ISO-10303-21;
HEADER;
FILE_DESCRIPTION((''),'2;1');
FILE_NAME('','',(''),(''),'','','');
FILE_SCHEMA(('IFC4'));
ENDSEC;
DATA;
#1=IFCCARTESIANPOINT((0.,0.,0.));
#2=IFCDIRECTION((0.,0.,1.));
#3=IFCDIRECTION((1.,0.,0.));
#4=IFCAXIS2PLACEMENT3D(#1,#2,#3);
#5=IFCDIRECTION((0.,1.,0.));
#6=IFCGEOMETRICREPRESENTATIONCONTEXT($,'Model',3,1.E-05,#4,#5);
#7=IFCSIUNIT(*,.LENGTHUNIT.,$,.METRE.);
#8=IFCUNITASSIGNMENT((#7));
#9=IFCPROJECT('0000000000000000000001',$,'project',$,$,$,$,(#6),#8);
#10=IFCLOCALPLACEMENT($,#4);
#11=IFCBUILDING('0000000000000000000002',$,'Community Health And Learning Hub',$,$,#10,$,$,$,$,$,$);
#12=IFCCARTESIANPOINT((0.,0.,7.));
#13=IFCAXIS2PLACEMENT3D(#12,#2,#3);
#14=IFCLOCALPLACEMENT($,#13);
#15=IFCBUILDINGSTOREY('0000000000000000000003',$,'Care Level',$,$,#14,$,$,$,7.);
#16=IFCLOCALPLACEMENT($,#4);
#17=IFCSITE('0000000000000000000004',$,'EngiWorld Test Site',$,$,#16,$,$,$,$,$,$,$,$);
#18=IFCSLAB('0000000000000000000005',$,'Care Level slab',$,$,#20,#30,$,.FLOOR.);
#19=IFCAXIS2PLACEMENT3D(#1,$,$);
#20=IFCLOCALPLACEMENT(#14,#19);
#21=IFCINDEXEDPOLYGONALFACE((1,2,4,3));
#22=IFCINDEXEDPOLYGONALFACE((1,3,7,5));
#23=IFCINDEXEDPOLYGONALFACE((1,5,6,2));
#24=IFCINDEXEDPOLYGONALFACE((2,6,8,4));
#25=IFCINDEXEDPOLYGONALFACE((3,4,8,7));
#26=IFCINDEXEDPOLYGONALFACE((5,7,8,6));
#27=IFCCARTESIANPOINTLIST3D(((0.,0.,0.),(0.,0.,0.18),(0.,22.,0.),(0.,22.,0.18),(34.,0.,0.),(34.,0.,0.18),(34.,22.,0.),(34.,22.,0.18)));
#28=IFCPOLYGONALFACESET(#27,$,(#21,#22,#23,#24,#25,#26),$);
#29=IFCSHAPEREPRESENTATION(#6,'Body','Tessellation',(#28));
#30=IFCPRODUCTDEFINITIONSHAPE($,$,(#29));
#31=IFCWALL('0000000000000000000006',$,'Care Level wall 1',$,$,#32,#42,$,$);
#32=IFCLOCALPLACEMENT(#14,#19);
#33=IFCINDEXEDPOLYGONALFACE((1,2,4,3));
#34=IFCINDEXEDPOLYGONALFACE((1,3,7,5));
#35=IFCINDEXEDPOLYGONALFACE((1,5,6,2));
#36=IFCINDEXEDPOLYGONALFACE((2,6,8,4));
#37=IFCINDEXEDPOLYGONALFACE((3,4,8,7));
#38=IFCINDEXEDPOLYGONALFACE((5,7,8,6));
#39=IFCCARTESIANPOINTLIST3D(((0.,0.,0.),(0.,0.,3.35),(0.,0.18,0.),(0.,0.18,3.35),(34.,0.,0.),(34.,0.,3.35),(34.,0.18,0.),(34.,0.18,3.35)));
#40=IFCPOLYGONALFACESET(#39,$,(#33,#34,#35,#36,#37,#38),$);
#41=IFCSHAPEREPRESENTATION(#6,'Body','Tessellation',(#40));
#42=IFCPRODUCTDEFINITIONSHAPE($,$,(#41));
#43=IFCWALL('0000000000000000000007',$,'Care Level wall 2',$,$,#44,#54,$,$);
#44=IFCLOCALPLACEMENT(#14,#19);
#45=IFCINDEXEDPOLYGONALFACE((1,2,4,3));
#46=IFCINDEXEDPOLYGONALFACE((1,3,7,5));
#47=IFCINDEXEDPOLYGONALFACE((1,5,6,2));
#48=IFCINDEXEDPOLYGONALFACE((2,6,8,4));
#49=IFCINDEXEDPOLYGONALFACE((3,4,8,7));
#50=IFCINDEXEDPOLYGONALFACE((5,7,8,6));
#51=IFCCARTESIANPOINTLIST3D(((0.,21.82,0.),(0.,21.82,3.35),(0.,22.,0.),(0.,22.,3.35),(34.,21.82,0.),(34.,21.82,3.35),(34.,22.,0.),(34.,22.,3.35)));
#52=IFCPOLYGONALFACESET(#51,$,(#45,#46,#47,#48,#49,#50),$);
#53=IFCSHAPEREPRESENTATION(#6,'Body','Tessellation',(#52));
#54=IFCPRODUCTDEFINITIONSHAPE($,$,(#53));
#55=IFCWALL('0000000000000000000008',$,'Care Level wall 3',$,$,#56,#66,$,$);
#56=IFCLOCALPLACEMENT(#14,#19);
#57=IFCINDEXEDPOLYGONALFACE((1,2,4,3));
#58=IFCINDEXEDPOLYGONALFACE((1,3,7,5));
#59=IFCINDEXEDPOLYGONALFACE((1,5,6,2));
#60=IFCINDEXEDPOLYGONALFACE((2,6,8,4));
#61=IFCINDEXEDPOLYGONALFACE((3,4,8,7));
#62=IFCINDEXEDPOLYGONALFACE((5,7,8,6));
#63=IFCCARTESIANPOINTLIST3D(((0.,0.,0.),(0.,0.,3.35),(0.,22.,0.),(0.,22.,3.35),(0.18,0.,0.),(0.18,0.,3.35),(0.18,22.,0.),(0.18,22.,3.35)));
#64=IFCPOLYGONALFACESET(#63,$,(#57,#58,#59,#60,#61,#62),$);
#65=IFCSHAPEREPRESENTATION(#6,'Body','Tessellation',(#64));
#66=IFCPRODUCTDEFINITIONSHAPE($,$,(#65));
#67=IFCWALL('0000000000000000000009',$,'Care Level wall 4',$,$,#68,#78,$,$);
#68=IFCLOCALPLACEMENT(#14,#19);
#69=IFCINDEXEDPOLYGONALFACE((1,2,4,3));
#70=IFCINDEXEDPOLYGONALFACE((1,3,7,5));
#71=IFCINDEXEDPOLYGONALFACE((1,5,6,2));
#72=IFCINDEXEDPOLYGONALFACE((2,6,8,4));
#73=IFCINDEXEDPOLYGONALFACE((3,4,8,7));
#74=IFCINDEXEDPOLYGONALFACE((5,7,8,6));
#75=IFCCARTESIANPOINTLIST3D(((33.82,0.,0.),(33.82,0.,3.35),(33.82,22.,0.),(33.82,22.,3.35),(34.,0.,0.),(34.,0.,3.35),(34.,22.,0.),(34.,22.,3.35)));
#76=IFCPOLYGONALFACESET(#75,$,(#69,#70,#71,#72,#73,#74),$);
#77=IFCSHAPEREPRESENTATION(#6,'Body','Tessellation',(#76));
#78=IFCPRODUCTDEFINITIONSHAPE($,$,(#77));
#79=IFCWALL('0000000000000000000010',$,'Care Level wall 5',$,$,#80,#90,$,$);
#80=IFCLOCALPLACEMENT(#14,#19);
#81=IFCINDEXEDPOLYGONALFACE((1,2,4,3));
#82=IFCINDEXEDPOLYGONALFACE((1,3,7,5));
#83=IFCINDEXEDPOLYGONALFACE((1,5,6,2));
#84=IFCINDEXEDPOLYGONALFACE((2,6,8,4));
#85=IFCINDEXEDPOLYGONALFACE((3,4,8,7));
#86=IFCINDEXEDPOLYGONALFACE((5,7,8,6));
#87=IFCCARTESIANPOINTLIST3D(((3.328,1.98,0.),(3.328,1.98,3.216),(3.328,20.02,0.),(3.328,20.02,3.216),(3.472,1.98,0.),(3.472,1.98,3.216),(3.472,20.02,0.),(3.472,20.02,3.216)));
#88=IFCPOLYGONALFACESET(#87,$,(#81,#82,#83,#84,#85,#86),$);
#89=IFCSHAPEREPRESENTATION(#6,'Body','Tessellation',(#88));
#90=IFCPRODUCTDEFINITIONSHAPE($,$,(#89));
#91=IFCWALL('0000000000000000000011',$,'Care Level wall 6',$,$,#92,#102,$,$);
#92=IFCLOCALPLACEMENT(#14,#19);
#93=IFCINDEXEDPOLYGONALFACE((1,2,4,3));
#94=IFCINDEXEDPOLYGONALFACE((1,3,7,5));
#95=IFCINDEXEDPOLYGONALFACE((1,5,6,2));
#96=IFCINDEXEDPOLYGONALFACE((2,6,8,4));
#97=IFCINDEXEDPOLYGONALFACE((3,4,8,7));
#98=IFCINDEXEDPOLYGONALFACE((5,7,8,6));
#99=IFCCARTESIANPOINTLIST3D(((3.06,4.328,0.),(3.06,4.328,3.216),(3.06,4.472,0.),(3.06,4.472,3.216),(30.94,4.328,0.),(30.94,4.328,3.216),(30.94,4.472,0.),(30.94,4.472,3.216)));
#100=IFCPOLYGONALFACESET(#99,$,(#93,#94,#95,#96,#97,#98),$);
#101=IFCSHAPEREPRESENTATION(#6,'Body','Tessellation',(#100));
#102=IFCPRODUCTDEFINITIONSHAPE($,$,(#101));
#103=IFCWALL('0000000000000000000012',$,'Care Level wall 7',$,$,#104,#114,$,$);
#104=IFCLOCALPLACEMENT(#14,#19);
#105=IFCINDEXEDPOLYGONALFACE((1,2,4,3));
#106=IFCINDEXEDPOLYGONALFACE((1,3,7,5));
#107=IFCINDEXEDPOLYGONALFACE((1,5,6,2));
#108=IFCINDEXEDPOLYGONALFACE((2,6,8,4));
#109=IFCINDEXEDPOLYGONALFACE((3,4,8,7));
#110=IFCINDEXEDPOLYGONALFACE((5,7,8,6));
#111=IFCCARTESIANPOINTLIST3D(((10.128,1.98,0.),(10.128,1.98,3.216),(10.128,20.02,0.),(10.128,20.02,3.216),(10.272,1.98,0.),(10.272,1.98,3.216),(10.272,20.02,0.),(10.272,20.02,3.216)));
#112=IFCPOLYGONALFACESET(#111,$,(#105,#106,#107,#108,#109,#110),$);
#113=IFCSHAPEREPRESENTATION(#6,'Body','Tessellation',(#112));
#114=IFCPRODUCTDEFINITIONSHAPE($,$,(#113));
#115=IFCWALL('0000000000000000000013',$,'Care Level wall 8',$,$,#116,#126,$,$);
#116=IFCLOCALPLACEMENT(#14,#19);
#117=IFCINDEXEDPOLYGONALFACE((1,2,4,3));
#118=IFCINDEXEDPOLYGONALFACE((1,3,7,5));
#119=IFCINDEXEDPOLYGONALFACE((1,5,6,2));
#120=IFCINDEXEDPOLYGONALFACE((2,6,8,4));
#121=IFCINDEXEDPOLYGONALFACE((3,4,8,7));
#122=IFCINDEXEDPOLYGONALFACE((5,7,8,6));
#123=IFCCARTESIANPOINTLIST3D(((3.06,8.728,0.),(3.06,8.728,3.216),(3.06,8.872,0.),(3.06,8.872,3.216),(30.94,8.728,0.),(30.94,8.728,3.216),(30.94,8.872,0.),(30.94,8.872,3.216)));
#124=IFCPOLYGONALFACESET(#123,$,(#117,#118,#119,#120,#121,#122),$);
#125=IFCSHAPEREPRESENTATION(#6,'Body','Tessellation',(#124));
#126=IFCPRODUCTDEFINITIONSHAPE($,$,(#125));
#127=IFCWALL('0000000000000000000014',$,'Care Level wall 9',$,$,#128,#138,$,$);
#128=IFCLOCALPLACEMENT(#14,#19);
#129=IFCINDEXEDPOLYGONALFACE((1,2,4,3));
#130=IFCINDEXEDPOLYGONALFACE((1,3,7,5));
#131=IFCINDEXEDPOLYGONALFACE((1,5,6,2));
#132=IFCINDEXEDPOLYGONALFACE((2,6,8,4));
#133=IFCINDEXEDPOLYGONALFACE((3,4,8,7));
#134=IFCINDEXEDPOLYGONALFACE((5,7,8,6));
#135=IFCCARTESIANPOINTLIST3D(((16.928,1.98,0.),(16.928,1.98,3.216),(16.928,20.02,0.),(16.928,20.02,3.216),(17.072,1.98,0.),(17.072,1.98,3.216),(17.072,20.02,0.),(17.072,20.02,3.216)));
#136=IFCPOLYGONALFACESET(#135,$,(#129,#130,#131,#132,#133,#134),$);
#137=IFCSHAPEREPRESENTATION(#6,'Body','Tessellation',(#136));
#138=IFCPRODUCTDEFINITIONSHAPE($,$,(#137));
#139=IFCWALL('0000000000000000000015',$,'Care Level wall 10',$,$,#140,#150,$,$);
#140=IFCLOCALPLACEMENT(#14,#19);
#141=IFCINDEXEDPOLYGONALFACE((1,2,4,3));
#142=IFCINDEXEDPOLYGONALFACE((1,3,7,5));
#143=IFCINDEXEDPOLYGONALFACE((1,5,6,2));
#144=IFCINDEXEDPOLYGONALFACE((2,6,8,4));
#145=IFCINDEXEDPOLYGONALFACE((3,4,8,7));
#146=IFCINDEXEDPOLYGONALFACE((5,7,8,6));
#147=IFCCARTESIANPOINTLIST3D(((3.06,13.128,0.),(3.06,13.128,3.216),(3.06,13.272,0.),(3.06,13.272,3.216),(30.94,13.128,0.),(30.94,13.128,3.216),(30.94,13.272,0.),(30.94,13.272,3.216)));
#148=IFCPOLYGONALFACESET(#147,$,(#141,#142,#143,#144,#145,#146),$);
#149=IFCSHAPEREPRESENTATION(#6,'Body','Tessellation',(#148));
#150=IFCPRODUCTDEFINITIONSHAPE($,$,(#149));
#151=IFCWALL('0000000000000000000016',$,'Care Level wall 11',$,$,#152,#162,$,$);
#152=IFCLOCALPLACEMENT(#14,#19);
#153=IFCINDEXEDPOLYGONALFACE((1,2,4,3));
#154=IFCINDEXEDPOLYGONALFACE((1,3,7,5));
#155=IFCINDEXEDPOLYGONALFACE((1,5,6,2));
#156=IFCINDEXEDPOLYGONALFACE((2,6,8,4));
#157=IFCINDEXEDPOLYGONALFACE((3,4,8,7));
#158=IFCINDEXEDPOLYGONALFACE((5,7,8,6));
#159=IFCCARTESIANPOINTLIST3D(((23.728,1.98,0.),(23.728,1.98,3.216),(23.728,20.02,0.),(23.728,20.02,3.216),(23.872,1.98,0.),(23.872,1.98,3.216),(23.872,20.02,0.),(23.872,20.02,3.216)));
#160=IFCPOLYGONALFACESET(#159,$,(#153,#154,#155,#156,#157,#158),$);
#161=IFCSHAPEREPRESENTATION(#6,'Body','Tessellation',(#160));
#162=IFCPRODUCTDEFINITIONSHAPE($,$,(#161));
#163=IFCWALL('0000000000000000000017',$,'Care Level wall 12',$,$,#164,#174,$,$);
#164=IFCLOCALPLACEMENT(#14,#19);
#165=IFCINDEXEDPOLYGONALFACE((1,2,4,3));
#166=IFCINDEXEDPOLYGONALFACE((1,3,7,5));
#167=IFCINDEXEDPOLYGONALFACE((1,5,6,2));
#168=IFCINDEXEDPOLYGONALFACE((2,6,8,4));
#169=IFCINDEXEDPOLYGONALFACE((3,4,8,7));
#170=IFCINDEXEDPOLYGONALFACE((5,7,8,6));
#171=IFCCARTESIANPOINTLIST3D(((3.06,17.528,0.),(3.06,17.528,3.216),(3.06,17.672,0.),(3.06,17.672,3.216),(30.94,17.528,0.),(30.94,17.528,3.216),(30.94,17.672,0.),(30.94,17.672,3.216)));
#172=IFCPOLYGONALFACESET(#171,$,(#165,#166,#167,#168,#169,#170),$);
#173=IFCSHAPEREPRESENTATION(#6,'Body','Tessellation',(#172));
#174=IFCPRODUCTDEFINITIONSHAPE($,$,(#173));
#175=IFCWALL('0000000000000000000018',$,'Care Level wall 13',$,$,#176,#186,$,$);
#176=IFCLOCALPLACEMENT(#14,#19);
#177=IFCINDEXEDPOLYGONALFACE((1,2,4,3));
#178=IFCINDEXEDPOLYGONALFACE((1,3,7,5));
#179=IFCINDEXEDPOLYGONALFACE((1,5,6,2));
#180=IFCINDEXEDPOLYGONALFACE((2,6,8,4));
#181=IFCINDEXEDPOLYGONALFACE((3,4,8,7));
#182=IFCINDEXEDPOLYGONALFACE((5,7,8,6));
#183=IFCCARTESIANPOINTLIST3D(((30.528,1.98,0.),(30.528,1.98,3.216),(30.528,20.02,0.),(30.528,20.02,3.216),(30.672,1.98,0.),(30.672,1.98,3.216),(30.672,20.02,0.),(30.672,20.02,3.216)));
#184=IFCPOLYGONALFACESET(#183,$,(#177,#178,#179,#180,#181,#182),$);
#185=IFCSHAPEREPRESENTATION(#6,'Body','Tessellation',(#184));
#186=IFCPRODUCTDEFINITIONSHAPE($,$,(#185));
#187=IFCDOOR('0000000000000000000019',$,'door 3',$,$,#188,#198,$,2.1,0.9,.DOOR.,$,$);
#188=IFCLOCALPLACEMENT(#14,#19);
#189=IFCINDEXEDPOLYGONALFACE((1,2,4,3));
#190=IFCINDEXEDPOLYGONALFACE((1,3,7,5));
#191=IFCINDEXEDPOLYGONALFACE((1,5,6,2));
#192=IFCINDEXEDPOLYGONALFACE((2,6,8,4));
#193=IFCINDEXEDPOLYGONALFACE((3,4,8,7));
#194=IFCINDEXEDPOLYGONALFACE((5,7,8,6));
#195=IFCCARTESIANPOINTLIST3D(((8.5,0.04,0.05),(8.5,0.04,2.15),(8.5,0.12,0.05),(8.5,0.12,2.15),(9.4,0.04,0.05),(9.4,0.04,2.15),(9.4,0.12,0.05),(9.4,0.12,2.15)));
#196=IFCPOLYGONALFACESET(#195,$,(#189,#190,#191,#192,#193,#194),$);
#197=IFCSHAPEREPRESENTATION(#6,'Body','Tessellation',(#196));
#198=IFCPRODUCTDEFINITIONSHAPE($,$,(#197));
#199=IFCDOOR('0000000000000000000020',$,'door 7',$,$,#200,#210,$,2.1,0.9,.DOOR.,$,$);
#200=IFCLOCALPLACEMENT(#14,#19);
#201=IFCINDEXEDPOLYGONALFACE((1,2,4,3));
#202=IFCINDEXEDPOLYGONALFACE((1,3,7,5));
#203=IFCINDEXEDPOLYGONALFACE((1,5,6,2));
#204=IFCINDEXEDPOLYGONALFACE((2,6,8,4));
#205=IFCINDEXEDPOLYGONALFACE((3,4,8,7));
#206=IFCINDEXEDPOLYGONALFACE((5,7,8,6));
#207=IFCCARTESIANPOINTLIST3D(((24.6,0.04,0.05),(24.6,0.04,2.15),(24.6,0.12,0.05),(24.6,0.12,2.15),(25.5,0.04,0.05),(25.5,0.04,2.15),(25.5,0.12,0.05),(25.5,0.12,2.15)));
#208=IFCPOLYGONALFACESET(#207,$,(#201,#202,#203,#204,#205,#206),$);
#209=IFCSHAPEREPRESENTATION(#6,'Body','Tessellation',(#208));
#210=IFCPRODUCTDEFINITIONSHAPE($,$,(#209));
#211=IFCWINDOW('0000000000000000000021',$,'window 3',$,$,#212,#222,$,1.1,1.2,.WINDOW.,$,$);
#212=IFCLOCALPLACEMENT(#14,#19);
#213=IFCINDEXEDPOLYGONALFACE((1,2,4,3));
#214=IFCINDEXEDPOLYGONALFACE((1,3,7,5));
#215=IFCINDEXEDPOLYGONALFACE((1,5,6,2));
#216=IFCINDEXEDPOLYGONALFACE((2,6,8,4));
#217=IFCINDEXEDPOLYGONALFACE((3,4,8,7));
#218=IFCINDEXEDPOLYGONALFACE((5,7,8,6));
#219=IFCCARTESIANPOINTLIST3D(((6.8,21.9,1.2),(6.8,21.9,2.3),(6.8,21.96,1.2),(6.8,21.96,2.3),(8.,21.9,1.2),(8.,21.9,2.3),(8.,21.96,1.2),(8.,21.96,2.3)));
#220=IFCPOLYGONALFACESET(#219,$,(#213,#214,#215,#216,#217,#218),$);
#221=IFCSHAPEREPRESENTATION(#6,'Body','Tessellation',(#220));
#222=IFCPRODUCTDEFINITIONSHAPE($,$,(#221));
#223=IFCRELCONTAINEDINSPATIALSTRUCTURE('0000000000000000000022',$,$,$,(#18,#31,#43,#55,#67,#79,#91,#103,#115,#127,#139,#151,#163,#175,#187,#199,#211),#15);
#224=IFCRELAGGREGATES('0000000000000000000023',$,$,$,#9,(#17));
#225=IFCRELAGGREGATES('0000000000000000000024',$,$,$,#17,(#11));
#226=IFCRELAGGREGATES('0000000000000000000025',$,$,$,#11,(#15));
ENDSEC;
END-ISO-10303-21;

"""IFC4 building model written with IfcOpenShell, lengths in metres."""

from ifc_helpers import new_model, si_unit, direction, frame, origin_with_axes, origin_2d_with_axis, place, context, project, spatial, rectangle, extrude, element, save


model = new_model("IFC4")

# Units and contexts
model_context = context("Model", 3, precision=1e-05, world=origin_with_axes(), true_north=direction((0.0, 1.0, 0.0)))
ifc_project = project(units=[si_unit("LENGTHUNIT", "METRE")], contexts=[model_context])

# Site, building, storey
site_placement = place(None, origin_with_axes())
site = spatial("IfcSite", under=ifc_project, at=site_placement, Name="EngiWorld Test Site")
building_placement = place(None, origin_with_axes())
building = spatial("IfcBuilding", under=site, at=building_placement, Name="Community Health And Learning Hub")
storey_placement = place(None, frame((0.0, 0.0, 7.0), z_axis=(0.0, 0.0, 1.0), x_axis=(1.0, 0.0, 0.0)))
storey = spatial("IfcBuildingStorey", under=building, at=storey_placement, Name="Care Level", Elevation=7.0)

# Slab
slab_placement = place(None, frame((17.0, 11.0, 7.0), z_axis=(0.0, 0.0, 1.0), x_axis=(1.0, 0.0, 0.0)))
element("IfcSlab", 1, at=slab_placement, inside=storey, Name="Care Level slab", PredefinedType="FLOOR", context=model_context, shape_type="SweptSolid", body=[
    extrude(rectangle(XDim=34.0, YDim=22.0, at=origin_2d_with_axis()), origin_with_axes(), (0.0, 0.0, 1.0), 0.18),
])

# Walls
for number, where, z_axis, x_axis, name in (
    (2, (17.0, 0.09, 7.0), (0.0, 0.0, 1.0), (1.0, 0.0, 0.0), "Care Level wall 1"),
    (3, (17.0, 21.91, 7.0), (0.0, 0.0, 1.0), (1.0, 0.0, 0.0), "Care Level wall 2"),
):
    element("IfcWall", number, at=place(None, frame(where, z_axis=z_axis, x_axis=x_axis)), inside=storey, Name=name, context=model_context, shape_type="SweptSolid", body=[
        extrude(rectangle(XDim=34.0, YDim=0.18, at=origin_2d_with_axis()), origin_with_axes(), (0.0, 0.0, 1.0), 3.35),
    ])
for number, where, z_axis, x_axis, name in (
    (4, (0.09, 11.0, 7.0), (0.0, 0.0, 1.0), (1.0, 0.0, 0.0), "Care Level wall 3"),
    (5, (33.91, 11.0, 7.0), (0.0, 0.0, 1.0), (1.0, 0.0, 0.0), "Care Level wall 4"),
):
    element("IfcWall", number, at=place(None, frame(where, z_axis=z_axis, x_axis=x_axis)), inside=storey, Name=name, context=model_context, shape_type="SweptSolid", body=[
        extrude(rectangle(XDim=0.18, YDim=22.0, at=origin_2d_with_axis()), origin_with_axes(), (0.0, 0.0, 1.0), 3.35),
    ])
wall_1_placement = place(None, frame((3.4, 11.0, 7.0), z_axis=(0.0, 0.0, 1.0), x_axis=(1.0, 0.0, 0.0)))
element("IfcWall", 6, at=wall_1_placement, inside=storey, Name="Care Level wall 5", context=model_context, shape_type="SweptSolid", body=[
    extrude(rectangle(XDim=0.144, YDim=18.04, at=origin_2d_with_axis()), origin_with_axes(), (0.0, 0.0, 1.0), 3.216),
])
wall_2_placement = place(None, frame((17.0, 4.4, 7.0), z_axis=(0.0, 0.0, 1.0), x_axis=(1.0, 0.0, 0.0)))
element("IfcWall", 7, at=wall_2_placement, inside=storey, Name="Care Level wall 6", context=model_context, shape_type="SweptSolid", body=[
    extrude(rectangle(XDim=27.88, YDim=0.144, at=origin_2d_with_axis()), origin_with_axes(), (0.0, 0.0, 1.0), 3.216),
])
wall_3_placement = place(None, frame((10.2, 11.0, 7.0), z_axis=(0.0, 0.0, 1.0), x_axis=(1.0, 0.0, 0.0)))
element("IfcWall", 8, at=wall_3_placement, inside=storey, Name="Care Level wall 7", context=model_context, shape_type="SweptSolid", body=[
    extrude(rectangle(XDim=0.144, YDim=18.04, at=origin_2d_with_axis()), origin_with_axes(), (0.0, 0.0, 1.0), 3.216),
])
wall_4_placement = place(None, frame((17.0, 8.8, 7.0), z_axis=(0.0, 0.0, 1.0), x_axis=(1.0, 0.0, 0.0)))
element("IfcWall", 9, at=wall_4_placement, inside=storey, Name="Care Level wall 8", context=model_context, shape_type="SweptSolid", body=[
    extrude(rectangle(XDim=27.88, YDim=0.144, at=origin_2d_with_axis()), origin_with_axes(), (0.0, 0.0, 1.0), 3.216),
])
wall_5_placement = place(None, frame((17.0, 11.0, 7.0), z_axis=(0.0, 0.0, 1.0), x_axis=(1.0, 0.0, 0.0)))
element("IfcWall", 10, at=wall_5_placement, inside=storey, Name="Care Level wall 9", context=model_context, shape_type="SweptSolid", body=[
    extrude(rectangle(XDim=0.144, YDim=18.04, at=origin_2d_with_axis()), origin_with_axes(), (0.0, 0.0, 1.0), 3.216),
])
wall_6_placement = place(None, frame((17.0, 13.2, 7.0), z_axis=(0.0, 0.0, 1.0), x_axis=(1.0, 0.0, 0.0)))
element("IfcWall", 11, at=wall_6_placement, inside=storey, Name="Care Level wall 10", context=model_context, shape_type="SweptSolid", body=[
    extrude(rectangle(XDim=27.88, YDim=0.144, at=origin_2d_with_axis()), origin_with_axes(), (0.0, 0.0, 1.0), 3.216),
])
wall_7_placement = place(None, frame((23.8, 11.0, 7.0), z_axis=(0.0, 0.0, 1.0), x_axis=(1.0, 0.0, 0.0)))
element("IfcWall", 12, at=wall_7_placement, inside=storey, Name="Care Level wall 11", context=model_context, shape_type="SweptSolid", body=[
    extrude(rectangle(XDim=0.144, YDim=18.04, at=origin_2d_with_axis()), origin_with_axes(), (0.0, 0.0, 1.0), 3.216),
])
wall_8_placement = place(None, frame((17.0, 17.6, 7.0), z_axis=(0.0, 0.0, 1.0), x_axis=(1.0, 0.0, 0.0)))
element("IfcWall", 13, at=wall_8_placement, inside=storey, Name="Care Level wall 12", context=model_context, shape_type="SweptSolid", body=[
    extrude(rectangle(XDim=27.88, YDim=0.144, at=origin_2d_with_axis()), origin_with_axes(), (0.0, 0.0, 1.0), 3.216),
])
wall_9_placement = place(None, frame((30.6, 11.0, 7.0), z_axis=(0.0, 0.0, 1.0), x_axis=(1.0, 0.0, 0.0)))
element("IfcWall", 14, at=wall_9_placement, inside=storey, Name="Care Level wall 13", context=model_context, shape_type="SweptSolid", body=[
    extrude(rectangle(XDim=0.144, YDim=18.04, at=origin_2d_with_axis()), origin_with_axes(), (0.0, 0.0, 1.0), 3.216),
])

# Doors
for number, where, z_axis, x_axis, name in (
    (15, (8.95, 0.08, 7.05), (0.0, 0.0, 1.0), (1.0, 0.0, 0.0), "door 3"),
    (16, (25.05, 0.08, 7.05), (0.0, 0.0, 1.0), (1.0, 0.0, 0.0), "door 7"),
):
    element("IfcDoor", number, at=place(None, frame(where, z_axis=z_axis, x_axis=x_axis)), inside=storey, Name=name, OverallHeight=2.1, OverallWidth=0.9, PredefinedType="DOOR", context=model_context, shape_type="SweptSolid", body=[
        extrude(rectangle(XDim=0.9, YDim=0.08, at=origin_2d_with_axis()), origin_with_axes(), (0.0, 0.0, 1.0), 2.1),
    ])

# Window
for number, where, z_axis, x_axis, name in (
    (17, (7.4, 21.93, 8.2), (0.0, 0.0, 1.0), (1.0, 0.0, 0.0), "window 3"),
):
    element("IfcWindow", number, at=place(None, frame(where, z_axis=z_axis, x_axis=x_axis)), inside=storey, Name=name, OverallHeight=1.1, OverallWidth=1.2, PredefinedType="WINDOW", context=model_context, shape_type="SweptSolid", body=[
        extrude(rectangle(XDim=1.2, YDim=0.06, at=origin_2d_with_axis()), origin_with_axes(), (0.0, 0.0, 1.0), 1.1),
    ])

save(model, "model.ifc")
